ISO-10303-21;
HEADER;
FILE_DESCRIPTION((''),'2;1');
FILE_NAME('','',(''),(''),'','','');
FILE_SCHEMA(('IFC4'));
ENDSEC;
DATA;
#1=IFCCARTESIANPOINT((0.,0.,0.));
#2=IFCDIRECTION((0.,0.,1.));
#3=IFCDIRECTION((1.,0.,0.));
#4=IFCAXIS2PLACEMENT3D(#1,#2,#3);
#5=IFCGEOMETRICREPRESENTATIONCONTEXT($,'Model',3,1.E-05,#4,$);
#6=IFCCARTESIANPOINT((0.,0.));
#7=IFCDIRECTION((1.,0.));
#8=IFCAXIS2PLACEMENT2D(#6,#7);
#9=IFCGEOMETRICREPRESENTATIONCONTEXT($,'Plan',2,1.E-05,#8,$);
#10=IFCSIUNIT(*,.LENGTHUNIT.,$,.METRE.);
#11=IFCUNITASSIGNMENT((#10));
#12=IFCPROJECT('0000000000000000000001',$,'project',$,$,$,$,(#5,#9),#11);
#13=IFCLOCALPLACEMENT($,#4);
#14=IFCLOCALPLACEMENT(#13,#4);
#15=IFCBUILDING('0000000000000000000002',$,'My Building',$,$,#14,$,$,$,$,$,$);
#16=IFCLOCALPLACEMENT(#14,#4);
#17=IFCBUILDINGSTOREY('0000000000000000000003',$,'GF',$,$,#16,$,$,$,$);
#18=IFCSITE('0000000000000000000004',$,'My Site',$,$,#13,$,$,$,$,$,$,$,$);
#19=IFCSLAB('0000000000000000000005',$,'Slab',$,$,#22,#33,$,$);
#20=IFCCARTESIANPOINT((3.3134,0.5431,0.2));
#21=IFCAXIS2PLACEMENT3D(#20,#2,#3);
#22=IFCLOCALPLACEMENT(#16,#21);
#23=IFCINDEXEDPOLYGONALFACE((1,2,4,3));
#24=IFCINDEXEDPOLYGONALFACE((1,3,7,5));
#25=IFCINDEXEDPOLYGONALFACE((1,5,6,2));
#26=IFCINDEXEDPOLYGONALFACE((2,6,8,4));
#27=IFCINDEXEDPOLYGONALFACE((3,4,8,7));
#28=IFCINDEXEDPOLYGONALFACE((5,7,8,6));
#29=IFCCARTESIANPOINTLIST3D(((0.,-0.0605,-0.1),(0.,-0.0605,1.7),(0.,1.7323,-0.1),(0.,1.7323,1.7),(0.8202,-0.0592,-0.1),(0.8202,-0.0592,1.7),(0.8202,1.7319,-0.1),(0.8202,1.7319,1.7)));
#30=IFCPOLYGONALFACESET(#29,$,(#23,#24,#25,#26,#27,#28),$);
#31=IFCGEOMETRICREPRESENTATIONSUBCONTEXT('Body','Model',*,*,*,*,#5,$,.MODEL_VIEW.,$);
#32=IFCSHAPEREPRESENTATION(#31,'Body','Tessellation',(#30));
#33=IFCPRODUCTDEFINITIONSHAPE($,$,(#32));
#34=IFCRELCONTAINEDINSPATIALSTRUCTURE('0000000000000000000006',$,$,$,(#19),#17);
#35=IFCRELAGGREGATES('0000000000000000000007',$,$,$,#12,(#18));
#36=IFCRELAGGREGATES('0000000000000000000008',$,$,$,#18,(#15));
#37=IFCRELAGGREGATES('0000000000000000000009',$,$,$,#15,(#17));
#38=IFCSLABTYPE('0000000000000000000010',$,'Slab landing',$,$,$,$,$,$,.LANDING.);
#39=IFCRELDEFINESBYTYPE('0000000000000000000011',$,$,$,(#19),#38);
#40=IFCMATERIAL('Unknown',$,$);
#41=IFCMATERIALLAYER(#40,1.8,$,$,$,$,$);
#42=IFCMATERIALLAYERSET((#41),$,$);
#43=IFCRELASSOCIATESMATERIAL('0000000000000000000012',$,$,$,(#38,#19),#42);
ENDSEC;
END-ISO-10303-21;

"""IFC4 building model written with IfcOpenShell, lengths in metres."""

from ifc_helpers import new_model, si_unit, frame, origin_with_axes, origin_2d_with_axis, place, context, subcontext, project, spatial, indexed_curve, outline, extrude, material, layer, layer_set, layer_usage, type_object, element, save


model = new_model("IFC4")

# Units and contexts
model_context = context("Model", 3, precision=1e-05, world=origin_with_axes())
plan_context = context("Plan", 2, precision=1e-05, world=origin_2d_with_axis())
body_context_1 = subcontext(model_context, "Body", "Model", "MODEL_VIEW")
ifc_project = project(units=[si_unit("LENGTHUNIT", "METRE")], contexts=[model_context, plan_context])

# Site, building, storey
site_placement = place(None, origin_with_axes())
site = spatial("IfcSite", under=ifc_project, at=site_placement, Name="My Site")
building_placement = place(site_placement, origin_with_axes())
building = spatial("IfcBuilding", under=site, at=building_placement, Name="My Building")
storey_placement = place(building_placement, origin_with_axes())
storey = spatial("IfcBuildingStorey", under=building, at=storey_placement, Name="GF")

# Slab
ifc_material_1 = material(Name="Unknown")
ifc_layer_1 = layer(ifc_material_1, 1.8)
ifc_layer_set_1 = layer_set([ifc_layer_1])
ifc_layer_usage_1 = layer_usage(ifc_layer_set_1, "AXIS3", "POSITIVE", -0.1)
slab_type_1 = type_object("IfcSlabType", Name="Slab landing", PredefinedType="LANDING", material=ifc_layer_set_1)
slab_1_placement = place(storey_placement, frame((3.3134, 0.5431, 0.2), z_axis=(0.0, 0.0, 1.0), x_axis=(1.0, 0.0, 0.0)))
element("IfcSlab", 1, at=slab_1_placement, inside=storey, type_object=slab_type_1, material=ifc_layer_usage_1, Name="Slab", context=body_context_1, shape_type="SweptSolid", body=[
    extrude(outline(indexed_curve([(0.0, -0.0605), (0.0, 1.7323), (0.8202, 1.7319), (0.8202, -0.0592), (0.0, -0.0605)])), frame((0.0, 0.0, -0.1), z_axis=(0.0, 0.0, 1.0), x_axis=(1.0, 0.0, 0.0)), (0.0, 0.0, 1.0), 1.8),
])

save(model, "model.ifc")
